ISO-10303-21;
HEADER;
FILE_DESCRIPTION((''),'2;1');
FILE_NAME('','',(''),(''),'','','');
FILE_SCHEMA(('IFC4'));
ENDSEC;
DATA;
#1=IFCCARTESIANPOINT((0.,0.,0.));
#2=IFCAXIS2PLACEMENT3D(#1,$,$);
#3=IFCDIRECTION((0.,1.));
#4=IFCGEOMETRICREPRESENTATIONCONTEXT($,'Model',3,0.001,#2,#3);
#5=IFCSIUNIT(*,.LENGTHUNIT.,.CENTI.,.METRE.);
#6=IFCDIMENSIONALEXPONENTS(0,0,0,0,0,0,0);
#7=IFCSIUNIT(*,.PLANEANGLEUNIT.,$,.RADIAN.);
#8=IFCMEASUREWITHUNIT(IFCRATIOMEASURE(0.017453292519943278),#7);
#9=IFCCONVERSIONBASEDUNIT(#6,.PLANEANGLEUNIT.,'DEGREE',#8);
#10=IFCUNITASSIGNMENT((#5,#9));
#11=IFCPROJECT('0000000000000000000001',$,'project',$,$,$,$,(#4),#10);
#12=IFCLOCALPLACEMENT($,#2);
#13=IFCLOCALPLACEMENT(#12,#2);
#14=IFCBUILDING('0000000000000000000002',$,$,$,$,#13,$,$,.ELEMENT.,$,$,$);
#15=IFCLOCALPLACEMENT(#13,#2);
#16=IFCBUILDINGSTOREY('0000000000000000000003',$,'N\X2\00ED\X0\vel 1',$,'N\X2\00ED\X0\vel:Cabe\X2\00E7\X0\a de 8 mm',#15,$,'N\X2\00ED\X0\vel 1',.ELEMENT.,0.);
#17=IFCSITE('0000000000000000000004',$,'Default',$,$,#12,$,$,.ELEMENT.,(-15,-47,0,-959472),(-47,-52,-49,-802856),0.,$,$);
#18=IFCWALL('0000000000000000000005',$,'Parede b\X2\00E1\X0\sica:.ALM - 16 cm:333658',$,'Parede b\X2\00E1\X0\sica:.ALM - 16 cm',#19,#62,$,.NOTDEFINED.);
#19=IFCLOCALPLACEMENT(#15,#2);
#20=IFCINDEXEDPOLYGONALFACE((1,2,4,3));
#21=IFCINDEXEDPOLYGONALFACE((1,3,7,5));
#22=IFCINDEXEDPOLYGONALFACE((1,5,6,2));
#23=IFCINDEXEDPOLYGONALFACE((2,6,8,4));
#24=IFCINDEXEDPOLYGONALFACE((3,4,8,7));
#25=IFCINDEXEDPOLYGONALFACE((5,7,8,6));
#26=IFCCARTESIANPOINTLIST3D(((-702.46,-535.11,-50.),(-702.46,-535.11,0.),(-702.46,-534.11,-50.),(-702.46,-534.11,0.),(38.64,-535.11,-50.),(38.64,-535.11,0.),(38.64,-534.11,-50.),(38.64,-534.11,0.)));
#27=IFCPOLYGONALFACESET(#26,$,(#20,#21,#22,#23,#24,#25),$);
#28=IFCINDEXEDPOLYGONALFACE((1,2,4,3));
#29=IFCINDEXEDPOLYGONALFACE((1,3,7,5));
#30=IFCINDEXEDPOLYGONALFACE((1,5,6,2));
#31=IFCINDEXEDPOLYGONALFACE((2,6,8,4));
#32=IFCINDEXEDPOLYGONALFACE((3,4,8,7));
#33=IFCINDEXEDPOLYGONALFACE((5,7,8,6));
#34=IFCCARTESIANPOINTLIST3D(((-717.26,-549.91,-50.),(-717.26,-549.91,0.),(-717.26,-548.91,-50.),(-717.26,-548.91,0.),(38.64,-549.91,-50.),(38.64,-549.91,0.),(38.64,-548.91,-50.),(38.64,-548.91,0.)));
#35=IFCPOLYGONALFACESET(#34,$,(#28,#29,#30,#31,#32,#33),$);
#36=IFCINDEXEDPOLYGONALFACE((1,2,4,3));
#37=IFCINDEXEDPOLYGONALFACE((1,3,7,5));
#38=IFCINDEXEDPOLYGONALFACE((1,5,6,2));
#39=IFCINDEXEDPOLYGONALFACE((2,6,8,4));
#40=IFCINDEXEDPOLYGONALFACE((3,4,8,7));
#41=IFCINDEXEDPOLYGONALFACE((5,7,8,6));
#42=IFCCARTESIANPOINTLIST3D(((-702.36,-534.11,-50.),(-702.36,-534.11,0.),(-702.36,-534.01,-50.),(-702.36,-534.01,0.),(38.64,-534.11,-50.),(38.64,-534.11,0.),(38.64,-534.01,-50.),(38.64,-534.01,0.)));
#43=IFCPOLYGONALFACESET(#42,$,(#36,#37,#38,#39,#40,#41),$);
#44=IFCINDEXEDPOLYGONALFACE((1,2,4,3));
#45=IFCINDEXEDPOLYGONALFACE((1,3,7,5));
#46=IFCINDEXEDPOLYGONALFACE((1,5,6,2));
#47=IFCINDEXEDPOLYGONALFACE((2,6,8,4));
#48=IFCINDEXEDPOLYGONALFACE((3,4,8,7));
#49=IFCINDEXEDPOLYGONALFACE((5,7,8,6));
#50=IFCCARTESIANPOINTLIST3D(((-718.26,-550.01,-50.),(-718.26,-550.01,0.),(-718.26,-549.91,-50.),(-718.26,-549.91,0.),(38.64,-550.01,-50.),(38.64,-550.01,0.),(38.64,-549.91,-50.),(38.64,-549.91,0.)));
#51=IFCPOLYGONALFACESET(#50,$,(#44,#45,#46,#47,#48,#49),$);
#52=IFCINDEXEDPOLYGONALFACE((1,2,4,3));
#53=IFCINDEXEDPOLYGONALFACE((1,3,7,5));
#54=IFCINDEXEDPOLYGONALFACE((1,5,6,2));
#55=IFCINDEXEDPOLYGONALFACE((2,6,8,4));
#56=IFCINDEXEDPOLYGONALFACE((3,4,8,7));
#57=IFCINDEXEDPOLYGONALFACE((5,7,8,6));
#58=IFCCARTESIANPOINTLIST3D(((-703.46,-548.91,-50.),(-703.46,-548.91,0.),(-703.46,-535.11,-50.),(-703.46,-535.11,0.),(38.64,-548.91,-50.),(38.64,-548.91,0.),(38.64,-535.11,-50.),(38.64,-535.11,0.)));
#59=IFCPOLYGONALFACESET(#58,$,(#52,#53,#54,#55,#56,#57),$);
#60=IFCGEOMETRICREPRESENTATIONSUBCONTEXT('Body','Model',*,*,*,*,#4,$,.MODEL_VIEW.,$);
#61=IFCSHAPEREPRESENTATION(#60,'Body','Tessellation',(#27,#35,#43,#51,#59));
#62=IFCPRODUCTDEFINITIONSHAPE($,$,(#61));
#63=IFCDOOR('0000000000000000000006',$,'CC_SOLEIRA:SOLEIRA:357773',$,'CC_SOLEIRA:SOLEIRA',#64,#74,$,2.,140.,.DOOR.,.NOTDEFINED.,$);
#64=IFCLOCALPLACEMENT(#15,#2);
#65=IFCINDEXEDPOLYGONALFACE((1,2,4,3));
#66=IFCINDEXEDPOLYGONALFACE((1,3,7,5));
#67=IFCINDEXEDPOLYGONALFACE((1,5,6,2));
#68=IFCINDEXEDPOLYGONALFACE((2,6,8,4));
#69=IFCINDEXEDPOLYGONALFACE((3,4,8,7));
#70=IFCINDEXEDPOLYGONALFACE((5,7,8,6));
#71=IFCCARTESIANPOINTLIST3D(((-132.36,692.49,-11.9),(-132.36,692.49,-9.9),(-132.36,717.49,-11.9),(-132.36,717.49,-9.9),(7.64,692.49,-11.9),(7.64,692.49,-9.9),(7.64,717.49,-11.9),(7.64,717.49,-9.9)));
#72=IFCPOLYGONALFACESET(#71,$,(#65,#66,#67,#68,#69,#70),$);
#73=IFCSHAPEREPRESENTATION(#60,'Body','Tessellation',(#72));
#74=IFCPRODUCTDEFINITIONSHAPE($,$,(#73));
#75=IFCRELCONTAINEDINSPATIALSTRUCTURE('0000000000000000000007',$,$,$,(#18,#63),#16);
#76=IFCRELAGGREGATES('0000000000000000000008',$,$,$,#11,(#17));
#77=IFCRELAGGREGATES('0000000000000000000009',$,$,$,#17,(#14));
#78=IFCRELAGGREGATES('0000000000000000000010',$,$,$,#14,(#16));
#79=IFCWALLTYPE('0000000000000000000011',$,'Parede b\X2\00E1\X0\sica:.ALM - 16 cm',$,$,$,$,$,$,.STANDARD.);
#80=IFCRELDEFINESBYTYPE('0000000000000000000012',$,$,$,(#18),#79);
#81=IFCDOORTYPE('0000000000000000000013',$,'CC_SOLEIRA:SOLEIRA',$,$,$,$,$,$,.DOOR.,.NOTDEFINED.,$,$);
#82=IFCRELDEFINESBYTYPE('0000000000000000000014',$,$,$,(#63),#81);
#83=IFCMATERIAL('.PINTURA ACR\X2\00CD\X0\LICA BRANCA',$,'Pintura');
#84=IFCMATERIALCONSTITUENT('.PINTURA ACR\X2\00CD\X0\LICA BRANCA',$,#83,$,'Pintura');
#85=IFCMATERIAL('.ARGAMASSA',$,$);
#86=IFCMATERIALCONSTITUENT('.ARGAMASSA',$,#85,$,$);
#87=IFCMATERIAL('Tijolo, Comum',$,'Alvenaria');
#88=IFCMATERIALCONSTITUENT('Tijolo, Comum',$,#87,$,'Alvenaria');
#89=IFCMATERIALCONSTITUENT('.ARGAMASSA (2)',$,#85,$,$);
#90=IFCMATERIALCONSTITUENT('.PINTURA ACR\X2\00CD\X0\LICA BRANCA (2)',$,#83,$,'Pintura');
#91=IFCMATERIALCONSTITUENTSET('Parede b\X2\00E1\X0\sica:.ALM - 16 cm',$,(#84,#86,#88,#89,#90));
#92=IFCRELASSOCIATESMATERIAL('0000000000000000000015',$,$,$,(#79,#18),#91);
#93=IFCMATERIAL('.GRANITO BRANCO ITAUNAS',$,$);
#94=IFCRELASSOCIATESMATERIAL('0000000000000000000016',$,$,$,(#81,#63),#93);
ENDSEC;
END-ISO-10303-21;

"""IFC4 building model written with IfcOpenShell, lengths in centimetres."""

from ifc_helpers import new_model, entity, si_unit, converted_unit, direction, frame, origin, place, context, subcontext, project, spatial, indexed_curve, outline, extrude, source, transform, mapped, material, constituent, constituent_set, type_object, type_shapes, element, save


model = new_model("IFC4")

# Units and contexts
model_context = context("Model", 3, precision=0.001, world=origin(), true_north=direction((0.0, 1.0)))
body_context = subcontext(model_context, "Body", "Model", "MODEL_VIEW")
ifc_project = project(units=[si_unit("LENGTHUNIT", "METRE", prefix="CENTI"), converted_unit("PLANEANGLEUNIT", "DEGREE", entity("IfcRatioMeasure", 0.017453292519943278), si_unit("PLANEANGLEUNIT", "RADIAN"), dimensions=[0, 0, 0, 0, 0, 0, 0])], contexts=[model_context])

# Site, building, storey
site_placement = place(None, origin())
site = spatial("IfcSite", under=ifc_project, at=site_placement, Name="Default", CompositionType="ELEMENT", RefLatitude=(-15, -47, 0, -959472), RefLongitude=(-47, -52, -49, -802856), RefElevation=0.0)
building_placement = place(site_placement, origin())
building = spatial("IfcBuilding", under=site, at=building_placement, CompositionType="ELEMENT")
storey_placement = place(building_placement, origin())
storey = spatial("IfcBuildingStorey", under=building, at=storey_placement, Name="Nível 1", ObjectType="Nível:Cabeça de 8 mm", LongName="Nível 1", CompositionType="ELEMENT", Elevation=0.0)

# Shared definitions
ifc_material_1 = material(Name=".PINTURA ACRÍLICA BRANCA", Category="Pintura")
ifc_material_2 = material(Name=".ARGAMASSA")
ifc_material_3 = material(Name="Tijolo, Comum", Category="Alvenaria")

# Wall
ifc_constituent_1 = constituent(ifc_material_1, Name=".PINTURA ACRÍLICA BRANCA", Category="Pintura")
ifc_constituent_2 = constituent(ifc_material_2, Name=".ARGAMASSA")
ifc_constituent_3 = constituent(ifc_material_3, Name="Tijolo, Comum", Category="Alvenaria")
ifc_constituent_4 = constituent(ifc_material_2, Name=".ARGAMASSA (2)")
ifc_constituent_5 = constituent(ifc_material_1, Name=".PINTURA ACRÍLICA BRANCA (2)", Category="Pintura")
ifc_constituent_set_1 = constituent_set(constituents=[ifc_constituent_1, ifc_constituent_2, ifc_constituent_3, ifc_constituent_4, ifc_constituent_5], Name="Parede básica:.ALM - 16 cm")
wall_type_1 = type_object("IfcWallType", Name="Parede básica:.ALM - 16 cm", PredefinedType="STANDARD", material=ifc_constituent_set_1)
wall_1_placement = place(storey_placement, frame((-702.36, -542.01, -50.0)))
element("IfcWall", 1, at=wall_1_placement, inside=storey, type_object=wall_type_1, material=ifc_constituent_set_1, Name="Parede básica:.ALM - 16 cm:333658", ObjectType="Parede básica:.ALM - 16 cm", PredefinedType="NOTDEFINED", context=body_context, shape_type="SweptSolid", body=[
    extrude(outline(indexed_curve([(-370.55, -0.5), (370.55, -0.5), (370.55, 0.5), (-370.55, 0.5), (-370.55, -0.5)], self_intersect=False)), frame((370.45, 7.4, 0.0)), (0.0, 0.0, 1.0), 50.0),
    extrude(outline(indexed_curve([(-377.95, -0.5), (377.95, -0.5), (377.95, 0.5), (-377.95, 0.5), (-377.95, -0.5)], self_intersect=False)), frame((363.05, -7.4, 0.0)), (0.0, 0.0, 1.0), 50.0),
    extrude(outline(indexed_curve([(-0.05, -370.5), (0.05, -370.5), (0.05, 370.5), (-0.05, 370.5), (-0.05, -370.5)], self_intersect=False)), frame((370.5, 7.95, 0.0), z_axis=(0.0, 0.0, 1.0), x_axis=(0.0, -1.0, 0.0)), (0.0, 0.0, 1.0), 50.0),
    extrude(outline(indexed_curve([(-0.05, -378.45), (0.05, -378.45), (0.05, 378.45), (-0.05, 378.45), (-0.05, -378.45)], self_intersect=False)), frame((362.55, -7.95, 0.0), z_axis=(0.0, 0.0, 1.0), x_axis=(0.0, 1.0, 0.0)), (0.0, 0.0, 1.0), 50.0),
    extrude(outline(indexed_curve([(-371.05, -6.9), (371.05, -6.9), (371.05, 6.9), (-371.05, 6.9), (-371.05, -6.9)], self_intersect=False)), frame((369.95, 0.0, 0.0)), (0.0, 0.0, 1.0), 50.0),
])

# Door
ifc_material_4 = material(Name=".GRANITO BRANCO ITAUNAS")
door_type = type_object("IfcDoorType", Name="CC_SOLEIRA:SOLEIRA", OperationType="NOTDEFINED", PredefinedType="DOOR", material=ifc_material_4)
shared_shape = source(origin(), body_context, "Body", "SweptSolid", [
    extrude(outline(indexed_curve([(-70.0, -12.5), (70.0, -12.5), (70.0, 12.5), (-70.0, 12.5), (-70.0, -12.5)], self_intersect=False)), frame((70.0, 12.5, 0.0), z_axis=(0.0, 0.0, 1.0), x_axis=(-1.0, 0.0, 0.0)), (0.0, 0.0, 1.0), 2.0),
])
type_shapes(door_type, [shared_shape])
door_placement = place(storey_placement, frame((-132.36, 692.49, -11.9)))
element("IfcDoor", 2, at=door_placement, inside=storey, type_object=door_type, material=ifc_material_4, Name="CC_SOLEIRA:SOLEIRA:357773", ObjectType="CC_SOLEIRA:SOLEIRA", OperationType="NOTDEFINED", OverallHeight=2.0, OverallWidth=140.0, PredefinedType="DOOR", context=body_context, shape_type="MappedRepresentation", body=[
    mapped(shared_shape, transform((0.0, 0.0, 0.0), scale=1.0)),
])

save(model, "model.ifc")
